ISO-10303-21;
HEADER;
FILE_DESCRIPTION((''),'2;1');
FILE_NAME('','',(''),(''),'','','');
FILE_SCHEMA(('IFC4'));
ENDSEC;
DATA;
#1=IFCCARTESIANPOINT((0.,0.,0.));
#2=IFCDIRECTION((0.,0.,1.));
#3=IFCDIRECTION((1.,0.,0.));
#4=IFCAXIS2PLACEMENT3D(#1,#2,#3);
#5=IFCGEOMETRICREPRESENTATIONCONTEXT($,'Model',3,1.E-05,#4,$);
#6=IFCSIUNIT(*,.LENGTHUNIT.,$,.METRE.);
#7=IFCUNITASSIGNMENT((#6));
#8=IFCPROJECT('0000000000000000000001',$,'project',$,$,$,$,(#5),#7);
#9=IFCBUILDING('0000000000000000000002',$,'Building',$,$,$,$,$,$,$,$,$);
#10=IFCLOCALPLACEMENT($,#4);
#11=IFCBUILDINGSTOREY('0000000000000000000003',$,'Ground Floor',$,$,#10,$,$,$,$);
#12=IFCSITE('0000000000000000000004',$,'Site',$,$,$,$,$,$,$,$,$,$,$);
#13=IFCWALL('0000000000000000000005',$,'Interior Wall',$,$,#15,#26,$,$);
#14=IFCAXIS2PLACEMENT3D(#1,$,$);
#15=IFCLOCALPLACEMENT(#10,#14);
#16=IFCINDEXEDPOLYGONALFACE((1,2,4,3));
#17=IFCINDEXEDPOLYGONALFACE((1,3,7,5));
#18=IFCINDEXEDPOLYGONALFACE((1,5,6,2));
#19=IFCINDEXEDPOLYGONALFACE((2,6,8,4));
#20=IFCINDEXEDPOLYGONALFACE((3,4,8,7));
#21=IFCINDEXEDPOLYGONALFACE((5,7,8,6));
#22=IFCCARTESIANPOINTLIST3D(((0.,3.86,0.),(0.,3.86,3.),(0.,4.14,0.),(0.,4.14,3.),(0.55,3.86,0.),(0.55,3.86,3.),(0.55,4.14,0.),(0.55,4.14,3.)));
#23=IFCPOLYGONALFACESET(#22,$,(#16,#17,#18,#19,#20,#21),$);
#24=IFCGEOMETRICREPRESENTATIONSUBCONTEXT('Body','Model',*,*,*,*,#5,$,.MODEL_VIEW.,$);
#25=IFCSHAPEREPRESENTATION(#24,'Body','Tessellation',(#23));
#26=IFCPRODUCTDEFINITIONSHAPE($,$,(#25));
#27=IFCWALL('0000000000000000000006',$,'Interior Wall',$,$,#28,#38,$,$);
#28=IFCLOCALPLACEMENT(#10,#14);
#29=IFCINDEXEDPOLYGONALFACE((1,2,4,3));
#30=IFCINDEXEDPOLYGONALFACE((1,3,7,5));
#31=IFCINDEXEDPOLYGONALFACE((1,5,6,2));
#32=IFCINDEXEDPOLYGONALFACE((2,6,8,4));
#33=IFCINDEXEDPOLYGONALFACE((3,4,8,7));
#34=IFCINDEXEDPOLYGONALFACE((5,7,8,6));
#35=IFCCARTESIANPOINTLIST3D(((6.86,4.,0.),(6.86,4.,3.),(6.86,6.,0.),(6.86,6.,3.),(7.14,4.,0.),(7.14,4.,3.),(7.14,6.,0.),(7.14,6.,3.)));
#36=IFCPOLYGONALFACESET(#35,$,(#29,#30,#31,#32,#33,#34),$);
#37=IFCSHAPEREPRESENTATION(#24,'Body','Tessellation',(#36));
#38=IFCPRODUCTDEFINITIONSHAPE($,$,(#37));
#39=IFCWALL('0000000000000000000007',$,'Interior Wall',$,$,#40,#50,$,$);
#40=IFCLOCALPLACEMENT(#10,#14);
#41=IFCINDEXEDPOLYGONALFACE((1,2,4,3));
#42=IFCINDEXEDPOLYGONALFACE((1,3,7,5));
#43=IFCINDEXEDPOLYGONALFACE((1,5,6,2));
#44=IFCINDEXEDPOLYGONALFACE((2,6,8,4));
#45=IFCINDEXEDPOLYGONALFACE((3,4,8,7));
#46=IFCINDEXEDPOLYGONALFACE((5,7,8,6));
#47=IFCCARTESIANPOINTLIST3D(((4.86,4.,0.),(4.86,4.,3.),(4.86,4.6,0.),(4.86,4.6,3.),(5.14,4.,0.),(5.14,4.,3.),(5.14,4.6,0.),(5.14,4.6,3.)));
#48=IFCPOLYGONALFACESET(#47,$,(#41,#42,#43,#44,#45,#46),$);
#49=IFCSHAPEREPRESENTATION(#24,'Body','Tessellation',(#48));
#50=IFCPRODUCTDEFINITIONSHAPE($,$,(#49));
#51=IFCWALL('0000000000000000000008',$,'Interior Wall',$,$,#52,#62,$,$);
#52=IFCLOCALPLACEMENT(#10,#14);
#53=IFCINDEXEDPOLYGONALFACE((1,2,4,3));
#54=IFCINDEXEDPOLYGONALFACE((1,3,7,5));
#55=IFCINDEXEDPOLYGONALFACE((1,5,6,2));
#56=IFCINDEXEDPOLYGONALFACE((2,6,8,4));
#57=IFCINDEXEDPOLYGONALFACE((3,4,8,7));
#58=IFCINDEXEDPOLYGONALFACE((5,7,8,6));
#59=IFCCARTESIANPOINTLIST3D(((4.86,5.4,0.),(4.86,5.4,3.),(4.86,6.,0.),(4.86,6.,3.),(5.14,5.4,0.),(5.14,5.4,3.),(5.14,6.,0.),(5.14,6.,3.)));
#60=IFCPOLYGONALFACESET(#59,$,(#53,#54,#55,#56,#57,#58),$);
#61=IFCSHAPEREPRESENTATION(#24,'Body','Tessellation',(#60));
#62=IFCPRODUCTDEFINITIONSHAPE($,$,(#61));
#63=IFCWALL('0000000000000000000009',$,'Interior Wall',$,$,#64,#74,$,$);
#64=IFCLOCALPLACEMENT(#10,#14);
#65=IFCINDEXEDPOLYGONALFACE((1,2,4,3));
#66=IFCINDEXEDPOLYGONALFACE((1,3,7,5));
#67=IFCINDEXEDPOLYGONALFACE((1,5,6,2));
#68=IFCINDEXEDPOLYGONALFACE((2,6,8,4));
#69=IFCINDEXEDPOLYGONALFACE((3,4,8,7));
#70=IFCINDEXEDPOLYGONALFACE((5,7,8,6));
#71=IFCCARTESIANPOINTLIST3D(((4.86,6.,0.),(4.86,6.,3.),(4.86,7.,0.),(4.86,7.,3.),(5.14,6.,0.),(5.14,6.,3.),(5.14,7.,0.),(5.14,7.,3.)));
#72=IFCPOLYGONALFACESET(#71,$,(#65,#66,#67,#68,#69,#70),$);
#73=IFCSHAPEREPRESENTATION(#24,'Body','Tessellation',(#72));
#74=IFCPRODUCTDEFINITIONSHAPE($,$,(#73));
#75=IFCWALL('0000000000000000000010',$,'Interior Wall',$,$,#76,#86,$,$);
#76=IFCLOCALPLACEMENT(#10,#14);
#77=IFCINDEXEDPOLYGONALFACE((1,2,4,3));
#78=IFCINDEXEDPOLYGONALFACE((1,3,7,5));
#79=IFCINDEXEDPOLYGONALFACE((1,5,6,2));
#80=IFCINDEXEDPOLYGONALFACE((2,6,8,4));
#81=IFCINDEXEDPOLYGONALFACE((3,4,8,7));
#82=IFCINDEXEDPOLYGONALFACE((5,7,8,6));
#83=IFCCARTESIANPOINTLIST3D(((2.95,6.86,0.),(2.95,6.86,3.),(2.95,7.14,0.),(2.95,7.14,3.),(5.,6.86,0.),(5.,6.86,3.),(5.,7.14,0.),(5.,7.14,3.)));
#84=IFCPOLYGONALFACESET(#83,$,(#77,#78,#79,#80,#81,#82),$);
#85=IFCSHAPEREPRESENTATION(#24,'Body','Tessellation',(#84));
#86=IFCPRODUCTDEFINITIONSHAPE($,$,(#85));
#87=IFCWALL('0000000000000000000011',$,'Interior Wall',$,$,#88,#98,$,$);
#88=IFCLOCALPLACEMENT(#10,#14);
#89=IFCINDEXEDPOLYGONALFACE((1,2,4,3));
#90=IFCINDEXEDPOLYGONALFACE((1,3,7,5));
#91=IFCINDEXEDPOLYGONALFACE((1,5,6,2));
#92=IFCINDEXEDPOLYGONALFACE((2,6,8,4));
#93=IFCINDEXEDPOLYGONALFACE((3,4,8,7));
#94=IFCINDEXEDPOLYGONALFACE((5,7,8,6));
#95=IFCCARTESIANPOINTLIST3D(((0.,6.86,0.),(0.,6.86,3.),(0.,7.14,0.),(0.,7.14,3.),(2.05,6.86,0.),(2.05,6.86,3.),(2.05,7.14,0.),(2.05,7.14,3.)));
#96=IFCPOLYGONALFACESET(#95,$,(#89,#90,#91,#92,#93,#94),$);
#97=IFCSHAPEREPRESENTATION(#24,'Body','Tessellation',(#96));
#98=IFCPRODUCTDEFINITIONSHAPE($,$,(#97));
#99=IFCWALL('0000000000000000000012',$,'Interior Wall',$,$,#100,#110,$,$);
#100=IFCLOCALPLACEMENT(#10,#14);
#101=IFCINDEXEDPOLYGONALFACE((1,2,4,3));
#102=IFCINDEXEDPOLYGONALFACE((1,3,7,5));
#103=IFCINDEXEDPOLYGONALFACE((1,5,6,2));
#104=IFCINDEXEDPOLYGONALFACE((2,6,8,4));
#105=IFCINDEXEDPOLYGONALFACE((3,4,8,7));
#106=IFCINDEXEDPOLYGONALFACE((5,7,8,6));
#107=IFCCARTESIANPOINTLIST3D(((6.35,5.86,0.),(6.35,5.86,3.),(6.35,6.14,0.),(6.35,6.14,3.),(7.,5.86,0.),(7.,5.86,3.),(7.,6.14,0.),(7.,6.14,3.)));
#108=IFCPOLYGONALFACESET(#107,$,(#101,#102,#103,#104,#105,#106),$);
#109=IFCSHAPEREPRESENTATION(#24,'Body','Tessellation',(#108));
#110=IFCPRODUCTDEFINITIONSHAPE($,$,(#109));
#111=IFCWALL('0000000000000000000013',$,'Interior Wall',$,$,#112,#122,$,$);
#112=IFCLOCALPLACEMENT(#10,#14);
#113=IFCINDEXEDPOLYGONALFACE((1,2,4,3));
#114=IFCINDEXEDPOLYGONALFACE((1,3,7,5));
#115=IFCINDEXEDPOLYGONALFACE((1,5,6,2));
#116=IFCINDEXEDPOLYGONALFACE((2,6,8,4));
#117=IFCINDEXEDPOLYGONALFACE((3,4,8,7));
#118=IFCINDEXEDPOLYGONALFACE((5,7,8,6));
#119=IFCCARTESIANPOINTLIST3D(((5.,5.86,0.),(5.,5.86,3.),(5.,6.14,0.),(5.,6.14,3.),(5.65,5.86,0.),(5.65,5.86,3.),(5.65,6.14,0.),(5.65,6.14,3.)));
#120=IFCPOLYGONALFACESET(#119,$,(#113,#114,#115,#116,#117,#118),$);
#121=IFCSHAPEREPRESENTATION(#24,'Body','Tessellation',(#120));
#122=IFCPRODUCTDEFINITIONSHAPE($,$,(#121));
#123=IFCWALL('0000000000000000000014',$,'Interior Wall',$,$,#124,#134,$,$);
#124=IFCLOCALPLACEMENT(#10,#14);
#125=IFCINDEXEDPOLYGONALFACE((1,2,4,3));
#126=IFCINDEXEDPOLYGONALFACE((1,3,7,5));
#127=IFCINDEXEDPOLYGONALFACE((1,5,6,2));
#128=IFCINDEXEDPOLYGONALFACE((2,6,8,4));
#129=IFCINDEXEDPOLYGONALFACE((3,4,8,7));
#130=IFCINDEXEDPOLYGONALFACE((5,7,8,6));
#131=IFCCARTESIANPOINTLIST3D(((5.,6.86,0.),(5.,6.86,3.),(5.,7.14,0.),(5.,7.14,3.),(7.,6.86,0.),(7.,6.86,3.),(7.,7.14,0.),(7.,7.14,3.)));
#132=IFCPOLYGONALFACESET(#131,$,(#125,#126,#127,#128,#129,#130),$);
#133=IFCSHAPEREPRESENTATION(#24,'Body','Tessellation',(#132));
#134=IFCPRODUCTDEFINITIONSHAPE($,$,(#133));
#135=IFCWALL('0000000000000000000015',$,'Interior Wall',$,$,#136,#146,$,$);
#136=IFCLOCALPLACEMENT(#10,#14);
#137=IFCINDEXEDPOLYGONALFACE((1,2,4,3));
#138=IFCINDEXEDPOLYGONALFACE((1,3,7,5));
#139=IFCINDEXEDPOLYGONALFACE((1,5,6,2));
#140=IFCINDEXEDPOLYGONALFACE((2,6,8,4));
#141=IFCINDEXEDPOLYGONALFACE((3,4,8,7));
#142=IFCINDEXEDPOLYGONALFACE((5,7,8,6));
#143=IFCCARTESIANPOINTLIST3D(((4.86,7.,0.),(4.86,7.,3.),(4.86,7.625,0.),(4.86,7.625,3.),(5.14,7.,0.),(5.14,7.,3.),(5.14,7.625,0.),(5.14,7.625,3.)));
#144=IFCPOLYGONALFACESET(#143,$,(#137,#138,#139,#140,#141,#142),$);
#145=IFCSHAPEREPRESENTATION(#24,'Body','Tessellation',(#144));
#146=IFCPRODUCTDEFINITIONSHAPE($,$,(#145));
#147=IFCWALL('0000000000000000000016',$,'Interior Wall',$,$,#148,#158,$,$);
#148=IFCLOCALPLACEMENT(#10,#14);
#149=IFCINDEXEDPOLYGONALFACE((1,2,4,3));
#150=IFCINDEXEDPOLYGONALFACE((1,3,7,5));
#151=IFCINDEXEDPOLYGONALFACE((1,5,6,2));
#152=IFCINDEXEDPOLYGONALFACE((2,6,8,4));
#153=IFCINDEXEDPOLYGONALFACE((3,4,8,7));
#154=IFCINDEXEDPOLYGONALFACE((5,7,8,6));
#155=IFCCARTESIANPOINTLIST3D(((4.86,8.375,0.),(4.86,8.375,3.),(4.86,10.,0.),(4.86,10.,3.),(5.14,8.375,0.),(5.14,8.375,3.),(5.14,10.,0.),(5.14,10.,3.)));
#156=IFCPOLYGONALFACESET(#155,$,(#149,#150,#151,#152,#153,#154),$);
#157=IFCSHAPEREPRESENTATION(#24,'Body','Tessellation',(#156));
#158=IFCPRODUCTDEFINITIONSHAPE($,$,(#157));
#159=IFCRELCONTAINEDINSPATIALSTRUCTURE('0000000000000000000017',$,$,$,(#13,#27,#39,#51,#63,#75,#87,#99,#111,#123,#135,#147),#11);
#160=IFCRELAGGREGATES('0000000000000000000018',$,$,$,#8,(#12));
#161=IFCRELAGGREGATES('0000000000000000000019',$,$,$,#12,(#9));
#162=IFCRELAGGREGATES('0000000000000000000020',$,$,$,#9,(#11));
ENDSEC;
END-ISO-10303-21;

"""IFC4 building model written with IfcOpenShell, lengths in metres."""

from ifc_helpers import new_model, si_unit, frame, origin_with_axes, place, context, subcontext, project, spatial, indexed_curve, outline, extrude, element, save


model = new_model("IFC4")

# Units and contexts
model_context = context("Model", 3, precision=1e-05, world=origin_with_axes())
body_context = subcontext(model_context, "Body", "Model", "MODEL_VIEW")
ifc_project = project(units=[si_unit("LENGTHUNIT", "METRE")], contexts=[model_context])

# Site, building, storey
site = spatial("IfcSite", under=ifc_project, Name="Site")
building = spatial("IfcBuilding", under=site, Name="Building")
storey_placement = place(None, origin_with_axes())
storey = spatial("IfcBuildingStorey", under=building, at=storey_placement, Name="Ground Floor")

# Walls
for number, where, z_axis, x_axis, name in (
    (1, (0.55, 4.0, 0.0), (0.0, 0.0, 1.0), (-1.0, 0.0, 0.0), "Interior Wall"),
):
    element("IfcWall", number, at=place(storey_placement, frame(where, z_axis=z_axis, x_axis=x_axis)), inside=storey, Name=name, context=body_context, shape_type="SweptSolid", body=[
        extrude(outline(indexed_curve([(0.0, 0.0), (0.0, 0.28), (0.55, 0.28), (0.55, 0.0), (0.0, 0.0)], self_intersect=False)), frame((0.0, -0.14, 0.0), z_axis=(0.0, 0.0, 1.0), x_axis=(1.0, 0.0, 0.0)), (0.0, 0.0, 1.0), 3.0),
    ])
wall_1_placement = place(storey_placement, frame((7.0, 6.0, 0.0), z_axis=(0.0, 0.0, 1.0), x_axis=(0.0, -1.0, 0.0)))
element("IfcWall", 2, at=wall_1_placement, inside=storey, Name="Interior Wall", context=body_context, shape_type="SweptSolid", body=[
    extrude(outline(indexed_curve([(0.0, 0.0), (0.0, 0.28), (2.0, 0.28), (2.0, 0.0), (0.0, 0.0)], self_intersect=False)), frame((0.0, -0.14, 0.0), z_axis=(0.0, 0.0, 1.0), x_axis=(1.0, 0.0, 0.0)), (0.0, 0.0, 1.0), 3.0),
])
for number, where, z_axis, x_axis, name in (
    (3, (5.0, 4.0, 0.0), (0.0, 0.0, 1.0), (0.0, 1.0, 0.0), "Interior Wall"),
    (4, (5.0, 5.4, 0.0), (0.0, 0.0, 1.0), (0.0, 1.0, 0.0), "Interior Wall"),
):
    element("IfcWall", number, at=place(storey_placement, frame(where, z_axis=z_axis, x_axis=x_axis)), inside=storey, Name=name, context=body_context, shape_type="SweptSolid", body=[
        extrude(outline(indexed_curve([(0.0, 0.0), (0.0, 0.28), (0.6, 0.28), (0.6, 0.0), (0.0, 0.0)], self_intersect=False)), frame((0.0, -0.14, 0.0), z_axis=(0.0, 0.0, 1.0), x_axis=(1.0, 0.0, 0.0)), (0.0, 0.0, 1.0), 3.0),
    ])
wall_2_placement = place(storey_placement, frame((5.0, 6.0, 0.0), z_axis=(0.0, 0.0, 1.0), x_axis=(0.0, 1.0, 0.0)))
element("IfcWall", 5, at=wall_2_placement, inside=storey, Name="Interior Wall", context=body_context, shape_type="SweptSolid", body=[
    extrude(outline(indexed_curve([(0.0, 0.0), (0.0, 0.28), (1.0, 0.28), (1.0, 0.0), (0.0, 0.0)], self_intersect=False)), frame((0.0, -0.14, 0.0), z_axis=(0.0, 0.0, 1.0), x_axis=(1.0, 0.0, 0.0)), (0.0, 0.0, 1.0), 3.0),
])
for number, where, z_axis, x_axis, name in (
    (6, (5.0, 7.0, 0.0), (0.0, 0.0, 1.0), (-1.0, 0.0, 0.0), "Interior Wall"),
    (7, (2.05, 7.0, 0.0), (0.0, 0.0, 1.0), (-1.0, 0.0, 0.0), "Interior Wall"),
):
    element("IfcWall", number, at=place(storey_placement, frame(where, z_axis=z_axis, x_axis=x_axis)), inside=storey, Name=name, context=body_context, shape_type="SweptSolid", body=[
        extrude(outline(indexed_curve([(0.0, 0.0), (0.0, 0.28), (2.05, 0.28), (2.05, 0.0), (0.0, 0.0)], self_intersect=False)), frame((0.0, -0.14, 0.0), z_axis=(0.0, 0.0, 1.0), x_axis=(1.0, 0.0, 0.0)), (0.0, 0.0, 1.0), 3.0),
    ])
for number, where, z_axis, x_axis, name in (
    (8, (7.0, 6.0, 0.0), (0.0, 0.0, 1.0), (-1.0, 0.0, 0.0), "Interior Wall"),
    (9, (5.65, 6.0, 0.0), (0.0, 0.0, 1.0), (-1.0, 0.0, 0.0), "Interior Wall"),
):
    element("IfcWall", number, at=place(storey_placement, frame(where, z_axis=z_axis, x_axis=x_axis)), inside=storey, Name=name, context=body_context, shape_type="SweptSolid", body=[
        extrude(outline(indexed_curve([(0.0, 0.0), (0.0, 0.28), (0.65, 0.28), (0.65, 0.0), (0.0, 0.0)], self_intersect=False)), frame((0.0, -0.14, 0.0), z_axis=(0.0, 0.0, 1.0), x_axis=(1.0, 0.0, 0.0)), (0.0, 0.0, 1.0), 3.0),
    ])
wall_3_placement = place(storey_placement, frame((7.0, 7.0, 0.0), z_axis=(0.0, 0.0, 1.0), x_axis=(-1.0, 0.0, 0.0)))
element("IfcWall", 10, at=wall_3_placement, inside=storey, Name="Interior Wall", context=body_context, shape_type="SweptSolid", body=[
    extrude(outline(indexed_curve([(0.0, 0.0), (0.0, 0.28), (2.0, 0.28), (2.0, 0.0), (0.0, 0.0)], self_intersect=False)), frame((0.0, -0.14, 0.0), z_axis=(0.0, 0.0, 1.0), x_axis=(1.0, 0.0, 0.0)), (0.0, 0.0, 1.0), 3.0),
])
wall_4_placement = place(storey_placement, frame((5.0, 7.0, 0.0), z_axis=(0.0, 0.0, 1.0), x_axis=(0.0, 1.0, 0.0)))
element("IfcWall", 11, at=wall_4_placement, inside=storey, Name="Interior Wall", context=body_context, shape_type="SweptSolid", body=[
    extrude(outline(indexed_curve([(0.0, 0.0), (0.0, 0.28), (0.625, 0.28), (0.625, 0.0), (0.0, 0.0)], self_intersect=False)), frame((0.0, -0.14, 0.0), z_axis=(0.0, 0.0, 1.0), x_axis=(1.0, 0.0, 0.0)), (0.0, 0.0, 1.0), 3.0),
])
wall_5_placement = place(storey_placement, frame((5.0, 8.375, 0.0), z_axis=(0.0, 0.0, 1.0), x_axis=(0.0, 1.0, 0.0)))
element("IfcWall", 12, at=wall_5_placement, inside=storey, Name="Interior Wall", context=body_context, shape_type="SweptSolid", body=[
    extrude(outline(indexed_curve([(0.0, 0.0), (0.0, 0.28), (1.625, 0.28), (1.625, 0.0), (0.0, 0.0)], self_intersect=False)), frame((0.0, -0.14, 0.0), z_axis=(0.0, 0.0, 1.0), x_axis=(1.0, 0.0, 0.0)), (0.0, 0.0, 1.0), 3.0),
])

save(model, "model.ifc")
